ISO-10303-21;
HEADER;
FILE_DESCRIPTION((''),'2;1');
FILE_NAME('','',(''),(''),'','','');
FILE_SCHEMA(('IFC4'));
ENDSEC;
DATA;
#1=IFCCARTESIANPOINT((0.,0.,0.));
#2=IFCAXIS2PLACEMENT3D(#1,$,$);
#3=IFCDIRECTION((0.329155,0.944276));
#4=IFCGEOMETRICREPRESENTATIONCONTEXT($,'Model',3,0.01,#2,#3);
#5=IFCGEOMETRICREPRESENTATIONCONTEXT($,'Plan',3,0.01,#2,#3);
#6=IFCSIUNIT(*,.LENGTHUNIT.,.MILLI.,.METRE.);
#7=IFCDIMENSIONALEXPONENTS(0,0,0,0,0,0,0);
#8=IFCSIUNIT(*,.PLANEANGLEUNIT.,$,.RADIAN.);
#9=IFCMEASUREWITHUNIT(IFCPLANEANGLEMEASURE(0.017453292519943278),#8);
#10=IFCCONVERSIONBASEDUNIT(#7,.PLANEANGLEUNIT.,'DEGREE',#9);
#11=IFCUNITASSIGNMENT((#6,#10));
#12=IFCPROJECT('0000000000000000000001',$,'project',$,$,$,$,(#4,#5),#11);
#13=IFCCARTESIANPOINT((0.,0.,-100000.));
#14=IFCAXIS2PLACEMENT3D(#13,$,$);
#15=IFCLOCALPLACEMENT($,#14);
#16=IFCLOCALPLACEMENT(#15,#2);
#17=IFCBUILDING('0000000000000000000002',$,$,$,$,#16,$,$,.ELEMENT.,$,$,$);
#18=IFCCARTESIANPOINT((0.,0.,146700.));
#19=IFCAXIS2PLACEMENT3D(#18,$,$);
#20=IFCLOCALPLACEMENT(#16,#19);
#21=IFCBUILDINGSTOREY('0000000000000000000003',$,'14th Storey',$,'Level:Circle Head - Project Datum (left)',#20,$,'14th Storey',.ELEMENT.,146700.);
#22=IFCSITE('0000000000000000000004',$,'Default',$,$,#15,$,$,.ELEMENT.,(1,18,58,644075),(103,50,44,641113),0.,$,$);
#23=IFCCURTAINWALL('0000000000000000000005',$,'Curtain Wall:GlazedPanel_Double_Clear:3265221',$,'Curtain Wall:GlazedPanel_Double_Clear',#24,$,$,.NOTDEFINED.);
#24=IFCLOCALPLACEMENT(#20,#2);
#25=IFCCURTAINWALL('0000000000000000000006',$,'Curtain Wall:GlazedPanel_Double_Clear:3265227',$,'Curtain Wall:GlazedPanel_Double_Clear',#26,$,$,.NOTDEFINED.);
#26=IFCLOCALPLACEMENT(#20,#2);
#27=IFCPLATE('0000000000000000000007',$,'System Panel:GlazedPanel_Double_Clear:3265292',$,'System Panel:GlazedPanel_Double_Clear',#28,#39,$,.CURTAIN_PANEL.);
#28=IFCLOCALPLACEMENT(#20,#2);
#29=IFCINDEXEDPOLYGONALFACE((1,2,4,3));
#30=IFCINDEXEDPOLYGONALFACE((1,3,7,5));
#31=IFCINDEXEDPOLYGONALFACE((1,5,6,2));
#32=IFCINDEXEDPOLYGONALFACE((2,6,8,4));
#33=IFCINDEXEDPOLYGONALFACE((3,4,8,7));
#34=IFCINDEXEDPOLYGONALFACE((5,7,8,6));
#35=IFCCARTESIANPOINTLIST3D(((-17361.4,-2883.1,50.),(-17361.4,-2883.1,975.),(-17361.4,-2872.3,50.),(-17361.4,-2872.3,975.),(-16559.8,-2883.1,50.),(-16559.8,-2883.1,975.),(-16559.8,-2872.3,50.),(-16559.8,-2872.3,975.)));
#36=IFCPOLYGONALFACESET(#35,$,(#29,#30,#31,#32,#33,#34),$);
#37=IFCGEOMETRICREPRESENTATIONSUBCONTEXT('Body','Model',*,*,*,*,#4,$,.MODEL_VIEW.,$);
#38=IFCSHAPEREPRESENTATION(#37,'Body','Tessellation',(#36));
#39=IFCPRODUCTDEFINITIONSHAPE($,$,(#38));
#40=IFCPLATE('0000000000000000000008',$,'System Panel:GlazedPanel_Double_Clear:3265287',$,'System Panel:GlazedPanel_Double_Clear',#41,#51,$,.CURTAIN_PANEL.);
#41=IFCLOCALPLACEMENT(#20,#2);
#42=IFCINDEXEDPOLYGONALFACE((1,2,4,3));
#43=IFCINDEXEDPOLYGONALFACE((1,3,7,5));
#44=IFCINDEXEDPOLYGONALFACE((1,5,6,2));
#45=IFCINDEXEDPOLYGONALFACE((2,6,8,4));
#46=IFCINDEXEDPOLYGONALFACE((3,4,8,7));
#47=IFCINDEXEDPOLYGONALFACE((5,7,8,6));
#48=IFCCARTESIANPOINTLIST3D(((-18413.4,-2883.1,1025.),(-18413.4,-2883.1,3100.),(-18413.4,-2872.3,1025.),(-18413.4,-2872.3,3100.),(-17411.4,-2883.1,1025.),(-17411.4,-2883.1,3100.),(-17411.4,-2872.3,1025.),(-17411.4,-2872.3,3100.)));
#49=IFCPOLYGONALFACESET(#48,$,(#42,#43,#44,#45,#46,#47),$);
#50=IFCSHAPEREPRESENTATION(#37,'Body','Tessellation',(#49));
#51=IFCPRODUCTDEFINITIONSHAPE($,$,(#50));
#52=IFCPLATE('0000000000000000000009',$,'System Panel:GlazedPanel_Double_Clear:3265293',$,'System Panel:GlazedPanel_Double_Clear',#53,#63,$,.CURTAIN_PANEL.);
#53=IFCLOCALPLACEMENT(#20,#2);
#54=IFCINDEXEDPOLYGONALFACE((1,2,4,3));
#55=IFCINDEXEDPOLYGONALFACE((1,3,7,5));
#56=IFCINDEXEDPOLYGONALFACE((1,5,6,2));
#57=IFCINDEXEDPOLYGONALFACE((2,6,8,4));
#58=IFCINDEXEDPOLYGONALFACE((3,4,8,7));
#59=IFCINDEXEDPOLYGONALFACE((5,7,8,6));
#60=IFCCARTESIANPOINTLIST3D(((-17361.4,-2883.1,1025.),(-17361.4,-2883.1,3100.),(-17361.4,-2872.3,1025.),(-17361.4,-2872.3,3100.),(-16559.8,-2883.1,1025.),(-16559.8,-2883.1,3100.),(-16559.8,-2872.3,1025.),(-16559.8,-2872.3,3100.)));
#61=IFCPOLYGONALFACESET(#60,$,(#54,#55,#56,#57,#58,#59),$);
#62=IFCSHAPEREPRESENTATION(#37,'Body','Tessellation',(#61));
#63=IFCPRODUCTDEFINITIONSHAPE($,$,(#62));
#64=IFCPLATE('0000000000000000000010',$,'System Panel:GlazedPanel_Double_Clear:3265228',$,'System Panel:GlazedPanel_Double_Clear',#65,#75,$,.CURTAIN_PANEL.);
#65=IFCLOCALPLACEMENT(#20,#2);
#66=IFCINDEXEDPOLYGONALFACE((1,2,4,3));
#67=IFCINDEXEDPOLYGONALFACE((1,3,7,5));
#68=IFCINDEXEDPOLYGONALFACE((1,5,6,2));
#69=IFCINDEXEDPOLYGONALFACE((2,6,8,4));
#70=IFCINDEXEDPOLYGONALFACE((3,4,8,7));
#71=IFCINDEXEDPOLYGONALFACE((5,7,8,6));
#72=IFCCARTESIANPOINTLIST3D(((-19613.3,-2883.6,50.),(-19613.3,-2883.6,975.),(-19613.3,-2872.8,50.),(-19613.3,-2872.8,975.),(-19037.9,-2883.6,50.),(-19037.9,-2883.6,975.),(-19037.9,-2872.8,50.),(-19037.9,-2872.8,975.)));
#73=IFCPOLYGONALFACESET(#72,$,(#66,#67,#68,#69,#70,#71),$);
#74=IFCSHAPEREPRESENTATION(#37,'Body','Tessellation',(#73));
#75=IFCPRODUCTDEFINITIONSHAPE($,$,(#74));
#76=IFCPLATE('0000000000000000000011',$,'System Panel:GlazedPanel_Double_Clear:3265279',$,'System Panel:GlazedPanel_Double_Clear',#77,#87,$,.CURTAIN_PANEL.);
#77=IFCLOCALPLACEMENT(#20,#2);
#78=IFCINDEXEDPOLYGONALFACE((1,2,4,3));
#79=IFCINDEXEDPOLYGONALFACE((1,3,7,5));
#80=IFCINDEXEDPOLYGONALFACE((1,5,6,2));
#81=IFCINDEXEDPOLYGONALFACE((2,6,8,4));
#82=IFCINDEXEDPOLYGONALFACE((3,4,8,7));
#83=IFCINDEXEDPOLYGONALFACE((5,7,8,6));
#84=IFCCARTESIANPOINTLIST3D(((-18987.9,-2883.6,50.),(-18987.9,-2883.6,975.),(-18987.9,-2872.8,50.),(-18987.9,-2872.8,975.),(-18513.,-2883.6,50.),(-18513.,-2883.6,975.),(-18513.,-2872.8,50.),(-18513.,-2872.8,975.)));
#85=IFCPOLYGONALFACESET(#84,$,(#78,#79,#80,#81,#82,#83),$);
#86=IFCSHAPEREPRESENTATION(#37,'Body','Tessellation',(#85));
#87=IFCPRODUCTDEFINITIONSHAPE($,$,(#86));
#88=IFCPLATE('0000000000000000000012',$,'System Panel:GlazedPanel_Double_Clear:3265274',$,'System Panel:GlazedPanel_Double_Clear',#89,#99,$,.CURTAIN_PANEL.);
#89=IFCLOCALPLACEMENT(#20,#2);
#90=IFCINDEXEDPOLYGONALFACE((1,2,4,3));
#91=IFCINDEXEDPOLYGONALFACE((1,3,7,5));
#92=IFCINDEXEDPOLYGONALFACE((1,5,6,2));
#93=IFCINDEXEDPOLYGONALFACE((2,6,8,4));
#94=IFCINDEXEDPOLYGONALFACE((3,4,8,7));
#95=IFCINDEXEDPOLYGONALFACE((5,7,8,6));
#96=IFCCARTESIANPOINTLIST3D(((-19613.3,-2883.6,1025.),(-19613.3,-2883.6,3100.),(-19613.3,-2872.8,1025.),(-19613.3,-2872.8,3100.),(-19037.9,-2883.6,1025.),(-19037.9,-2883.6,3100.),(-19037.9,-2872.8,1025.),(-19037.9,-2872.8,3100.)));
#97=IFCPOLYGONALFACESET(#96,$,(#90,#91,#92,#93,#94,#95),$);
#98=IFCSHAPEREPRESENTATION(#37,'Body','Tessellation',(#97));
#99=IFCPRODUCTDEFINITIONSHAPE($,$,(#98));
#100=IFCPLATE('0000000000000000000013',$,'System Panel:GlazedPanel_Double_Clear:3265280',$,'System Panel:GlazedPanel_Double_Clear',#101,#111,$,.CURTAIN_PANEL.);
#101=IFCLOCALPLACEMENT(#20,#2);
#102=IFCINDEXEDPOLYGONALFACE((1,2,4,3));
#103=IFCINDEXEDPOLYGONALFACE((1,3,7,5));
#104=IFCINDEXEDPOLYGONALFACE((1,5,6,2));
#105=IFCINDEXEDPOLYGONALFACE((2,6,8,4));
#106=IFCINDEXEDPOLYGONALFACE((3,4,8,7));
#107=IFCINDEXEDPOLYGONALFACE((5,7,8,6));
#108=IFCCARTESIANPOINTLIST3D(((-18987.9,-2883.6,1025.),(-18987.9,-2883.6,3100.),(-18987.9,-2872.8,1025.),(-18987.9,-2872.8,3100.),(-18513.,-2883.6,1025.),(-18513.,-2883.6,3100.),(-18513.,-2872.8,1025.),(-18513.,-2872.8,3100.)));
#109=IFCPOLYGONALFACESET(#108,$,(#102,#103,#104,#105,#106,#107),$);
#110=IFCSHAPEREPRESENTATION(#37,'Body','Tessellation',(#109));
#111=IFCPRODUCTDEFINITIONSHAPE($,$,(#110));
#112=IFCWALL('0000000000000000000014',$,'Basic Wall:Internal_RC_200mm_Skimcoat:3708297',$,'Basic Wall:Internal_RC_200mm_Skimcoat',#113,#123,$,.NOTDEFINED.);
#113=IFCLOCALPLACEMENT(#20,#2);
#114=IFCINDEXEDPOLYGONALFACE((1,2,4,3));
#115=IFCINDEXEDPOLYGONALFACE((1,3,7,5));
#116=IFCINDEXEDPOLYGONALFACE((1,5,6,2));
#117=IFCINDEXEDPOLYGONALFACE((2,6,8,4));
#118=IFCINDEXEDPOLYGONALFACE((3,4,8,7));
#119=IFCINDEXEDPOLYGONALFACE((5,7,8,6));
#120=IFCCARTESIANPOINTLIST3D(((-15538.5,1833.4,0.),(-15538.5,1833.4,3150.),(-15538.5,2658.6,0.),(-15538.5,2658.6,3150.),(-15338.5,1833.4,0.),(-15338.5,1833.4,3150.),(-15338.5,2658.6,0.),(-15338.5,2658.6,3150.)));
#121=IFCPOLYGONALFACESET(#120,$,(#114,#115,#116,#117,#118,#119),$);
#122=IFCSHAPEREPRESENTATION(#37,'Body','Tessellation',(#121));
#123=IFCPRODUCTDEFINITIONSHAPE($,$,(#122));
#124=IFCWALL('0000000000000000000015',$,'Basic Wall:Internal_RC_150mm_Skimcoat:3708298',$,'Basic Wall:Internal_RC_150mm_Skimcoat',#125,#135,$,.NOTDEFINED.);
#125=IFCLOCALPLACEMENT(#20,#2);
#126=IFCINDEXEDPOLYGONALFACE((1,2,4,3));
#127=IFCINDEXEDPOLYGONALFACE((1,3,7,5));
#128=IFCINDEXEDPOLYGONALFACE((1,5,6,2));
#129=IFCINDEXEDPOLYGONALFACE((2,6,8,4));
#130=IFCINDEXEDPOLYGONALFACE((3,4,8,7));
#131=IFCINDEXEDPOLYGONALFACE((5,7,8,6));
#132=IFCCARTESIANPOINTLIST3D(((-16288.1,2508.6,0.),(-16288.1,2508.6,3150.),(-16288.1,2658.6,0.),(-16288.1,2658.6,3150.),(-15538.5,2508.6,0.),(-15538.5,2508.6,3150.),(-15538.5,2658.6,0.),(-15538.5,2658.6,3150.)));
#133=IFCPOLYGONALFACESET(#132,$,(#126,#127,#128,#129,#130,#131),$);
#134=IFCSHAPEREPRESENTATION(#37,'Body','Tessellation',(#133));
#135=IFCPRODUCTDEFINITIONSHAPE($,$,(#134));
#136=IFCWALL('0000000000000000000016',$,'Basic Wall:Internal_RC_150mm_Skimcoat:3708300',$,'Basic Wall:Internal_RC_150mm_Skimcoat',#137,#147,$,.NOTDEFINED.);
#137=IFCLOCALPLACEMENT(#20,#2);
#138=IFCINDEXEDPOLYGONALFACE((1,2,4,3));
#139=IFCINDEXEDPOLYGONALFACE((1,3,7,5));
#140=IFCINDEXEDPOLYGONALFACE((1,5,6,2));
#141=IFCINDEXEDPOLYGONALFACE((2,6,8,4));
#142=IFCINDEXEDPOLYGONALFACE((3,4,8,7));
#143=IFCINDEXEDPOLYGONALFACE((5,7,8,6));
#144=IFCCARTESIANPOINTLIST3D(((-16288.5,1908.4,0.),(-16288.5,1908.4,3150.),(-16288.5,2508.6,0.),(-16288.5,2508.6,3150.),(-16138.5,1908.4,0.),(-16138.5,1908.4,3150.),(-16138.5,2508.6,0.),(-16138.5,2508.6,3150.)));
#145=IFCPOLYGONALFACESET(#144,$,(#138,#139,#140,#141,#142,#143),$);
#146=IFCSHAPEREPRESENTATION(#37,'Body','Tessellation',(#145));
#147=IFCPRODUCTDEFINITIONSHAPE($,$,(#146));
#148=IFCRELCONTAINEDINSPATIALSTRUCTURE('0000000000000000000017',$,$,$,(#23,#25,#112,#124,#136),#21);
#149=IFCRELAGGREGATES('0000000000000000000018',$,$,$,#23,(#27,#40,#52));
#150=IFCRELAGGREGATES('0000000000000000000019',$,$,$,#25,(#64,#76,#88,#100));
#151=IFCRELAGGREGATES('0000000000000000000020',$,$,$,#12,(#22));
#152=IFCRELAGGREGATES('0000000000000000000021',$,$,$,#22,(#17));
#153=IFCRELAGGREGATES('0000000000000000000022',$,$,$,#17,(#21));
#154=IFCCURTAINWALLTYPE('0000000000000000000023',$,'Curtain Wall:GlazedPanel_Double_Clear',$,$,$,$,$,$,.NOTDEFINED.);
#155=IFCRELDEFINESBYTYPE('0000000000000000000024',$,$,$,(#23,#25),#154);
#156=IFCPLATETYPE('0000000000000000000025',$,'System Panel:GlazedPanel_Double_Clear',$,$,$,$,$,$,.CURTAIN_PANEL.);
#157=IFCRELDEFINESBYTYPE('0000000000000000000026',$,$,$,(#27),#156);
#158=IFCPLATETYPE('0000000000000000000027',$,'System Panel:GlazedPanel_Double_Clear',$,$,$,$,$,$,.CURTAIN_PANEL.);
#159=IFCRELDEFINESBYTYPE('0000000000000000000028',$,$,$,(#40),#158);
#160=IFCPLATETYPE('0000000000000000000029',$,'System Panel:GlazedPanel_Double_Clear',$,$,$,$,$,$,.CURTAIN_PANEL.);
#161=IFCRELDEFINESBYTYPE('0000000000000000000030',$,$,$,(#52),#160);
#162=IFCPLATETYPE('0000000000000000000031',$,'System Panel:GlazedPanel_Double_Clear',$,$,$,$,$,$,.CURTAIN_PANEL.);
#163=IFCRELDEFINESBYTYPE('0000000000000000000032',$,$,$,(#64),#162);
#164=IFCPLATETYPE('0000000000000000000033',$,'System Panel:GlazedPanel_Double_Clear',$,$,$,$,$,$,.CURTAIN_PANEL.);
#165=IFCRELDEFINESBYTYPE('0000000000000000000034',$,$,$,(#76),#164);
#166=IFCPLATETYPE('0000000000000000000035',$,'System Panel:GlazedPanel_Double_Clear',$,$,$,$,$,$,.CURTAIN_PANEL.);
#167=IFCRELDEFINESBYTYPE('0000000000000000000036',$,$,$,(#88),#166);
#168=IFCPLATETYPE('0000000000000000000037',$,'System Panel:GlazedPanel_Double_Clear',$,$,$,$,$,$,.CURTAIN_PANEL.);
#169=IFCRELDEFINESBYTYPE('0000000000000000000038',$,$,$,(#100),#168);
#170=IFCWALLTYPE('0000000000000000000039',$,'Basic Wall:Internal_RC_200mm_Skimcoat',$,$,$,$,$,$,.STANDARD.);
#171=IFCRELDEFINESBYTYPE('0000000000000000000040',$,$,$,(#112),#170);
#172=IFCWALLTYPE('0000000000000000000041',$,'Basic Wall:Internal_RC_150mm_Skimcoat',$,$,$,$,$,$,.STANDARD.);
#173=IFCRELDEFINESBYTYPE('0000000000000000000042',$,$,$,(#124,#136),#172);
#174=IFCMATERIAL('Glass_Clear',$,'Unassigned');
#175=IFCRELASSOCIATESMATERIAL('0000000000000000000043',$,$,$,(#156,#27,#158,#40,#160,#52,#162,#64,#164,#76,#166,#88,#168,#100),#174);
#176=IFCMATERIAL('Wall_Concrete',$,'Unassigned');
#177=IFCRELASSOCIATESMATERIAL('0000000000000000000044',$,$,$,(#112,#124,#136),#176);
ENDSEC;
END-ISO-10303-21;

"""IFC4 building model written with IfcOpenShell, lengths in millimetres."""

from ifc_helpers import new_model, entity, si_unit, converted_unit, direction, frame, origin, place, context, subcontext, project, spatial, indexed_curve, outline, extrude, source, transform, mapped, material, type_object, type_shapes, element, aggregate, save


model = new_model("IFC4")

# Units and contexts
model_context = context("Model", 3, precision=0.01, world=origin(), true_north=direction((0.329155, 0.944276)))
plan_context = context("Plan", 3, precision=0.01, world=origin(), true_north=direction((0.329155, 0.944276)))
body_context = subcontext(model_context, "Body", "Model", "MODEL_VIEW")
ifc_project = project(units=[si_unit("LENGTHUNIT", "METRE", prefix="MILLI"), converted_unit("PLANEANGLEUNIT", "DEGREE", entity("IfcPlaneAngleMeasure", 0.017453292519943278), si_unit("PLANEANGLEUNIT", "RADIAN"), dimensions=[0, 0, 0, 0, 0, 0, 0])], contexts=[model_context, plan_context])

# Site, building, storey
site_placement = place(None, frame((0.0, 0.0, -100000.0)))
site = spatial("IfcSite", under=ifc_project, at=site_placement, Name="Default", CompositionType="ELEMENT", RefLatitude=(1, 18, 58, 644075), RefLongitude=(103, 50, 44, 641113), RefElevation=0.0)
building_placement = place(site_placement, origin())
building = spatial("IfcBuilding", under=site, at=building_placement, CompositionType="ELEMENT")
storey_placement = place(building_placement, frame((0.0, 0.0, 146700.0)))
storey = spatial("IfcBuildingStorey", under=building, at=storey_placement, Name="14th Storey", ObjectType="Level:Circle Head - Project Datum (left)", LongName="14th Storey", CompositionType="ELEMENT", Elevation=146700.0)

# Curtain wall
curtain_wall_type = type_object("IfcCurtainWallType", Name="Curtain Wall:GlazedPanel_Double_Clear", PredefinedType="NOTDEFINED")
curtain_wall_1_placement = place(storey_placement, frame((0.0, 0.0, -146700.0)))
curtain_wall_1 = element("IfcCurtainWall", 1, at=curtain_wall_1_placement, inside=storey, type_object=curtain_wall_type, Name="Curtain Wall:GlazedPanel_Double_Clear:3265221", ObjectType="Curtain Wall:GlazedPanel_Double_Clear", PredefinedType="NOTDEFINED")

# Curtain wall
curtain_wall_2_placement = place(storey_placement, frame((0.0, 0.0, -146700.0)))
curtain_wall_2 = element("IfcCurtainWall", 2, at=curtain_wall_2_placement, inside=storey, type_object=curtain_wall_type, Name="Curtain Wall:GlazedPanel_Double_Clear:3265227", ObjectType="Curtain Wall:GlazedPanel_Double_Clear", PredefinedType="NOTDEFINED")

# Plates
ifc_material_1 = material(Name="Glass_Clear", Category="Unassigned")
plate_type_1 = type_object("IfcPlateType", Name="System Panel:GlazedPanel_Double_Clear", PredefinedType="CURTAIN_PANEL", material=ifc_material_1)
shared_shape_1 = source(origin(), body_context, "Body", "SweptSolid", [
    extrude(outline(indexed_curve([(-5.4, -400.8), (5.4, -400.8), (5.4, 400.8), (-5.4, 400.8), (-5.4, -400.8)], self_intersect=False)), frame((400.8, 5.4, 0.0), z_axis=(0.0, 0.0, 1.0), x_axis=(0.0, 1.0, 0.0)), (0.0, 0.0, 1.0), 925.0),
])
type_shapes(plate_type_1, [shared_shape_1])
plate_1_placement = place(curtain_wall_1_placement, frame((-17361.4, -2883.1, 146750.0)))
plate_1 = element("IfcPlate", 3, at=plate_1_placement, type_object=plate_type_1, material=ifc_material_1, Name="System Panel:GlazedPanel_Double_Clear:3265292", ObjectType="System Panel:GlazedPanel_Double_Clear", PredefinedType="CURTAIN_PANEL", context=body_context, shape_type="MappedRepresentation", body=[
    mapped(shared_shape_1, transform((0.0, 0.0, 0.0), scale=1.0)),
])
plate_type_2 = type_object("IfcPlateType", Name="System Panel:GlazedPanel_Double_Clear", PredefinedType="CURTAIN_PANEL", material=ifc_material_1)
shared_shape_2 = source(origin(), body_context, "Body", "SweptSolid", [
    extrude(outline(indexed_curve([(-5.4, -501.0), (5.4, -501.0), (5.4, 501.0), (-5.4, 501.0), (-5.4, -501.0)], self_intersect=False)), frame((501.0, 5.4, 0.0), z_axis=(0.0, 0.0, 1.0), x_axis=(0.0, 1.0, 0.0)), (0.0, 0.0, 1.0), 2075.0),
])
type_shapes(plate_type_2, [shared_shape_2])
plate_2_placement = place(curtain_wall_1_placement, frame((-18413.4, -2883.1, 147725.0)))
plate_2 = element("IfcPlate", 4, at=plate_2_placement, type_object=plate_type_2, material=ifc_material_1, Name="System Panel:GlazedPanel_Double_Clear:3265287", ObjectType="System Panel:GlazedPanel_Double_Clear", PredefinedType="CURTAIN_PANEL", context=body_context, shape_type="MappedRepresentation", body=[
    mapped(shared_shape_2, transform((0.0, 0.0, 0.0), scale=1.0)),
])
plate_type_3 = type_object("IfcPlateType", Name="System Panel:GlazedPanel_Double_Clear", PredefinedType="CURTAIN_PANEL", material=ifc_material_1)
shared_shape_3 = source(origin(), body_context, "Body", "SweptSolid", [
    extrude(outline(indexed_curve([(-5.4, -400.8), (5.4, -400.8), (5.4, 400.8), (-5.4, 400.8), (-5.4, -400.8)], self_intersect=False)), frame((400.8, 5.4, 0.0), z_axis=(0.0, 0.0, 1.0), x_axis=(0.0, 1.0, 0.0)), (0.0, 0.0, 1.0), 2075.0),
])
type_shapes(plate_type_3, [shared_shape_3])
plate_3_placement = place(curtain_wall_1_placement, frame((-17361.4, -2883.1, 147725.0)))
plate_3 = element("IfcPlate", 5, at=plate_3_placement, type_object=plate_type_3, material=ifc_material_1, Name="System Panel:GlazedPanel_Double_Clear:3265293", ObjectType="System Panel:GlazedPanel_Double_Clear", PredefinedType="CURTAIN_PANEL", context=body_context, shape_type="MappedRepresentation", body=[
    mapped(shared_shape_3, transform((0.0, 0.0, 0.0), scale=1.0)),
])
aggregate(curtain_wall_1, [plate_1, plate_2, plate_3])
plate_type_4 = type_object("IfcPlateType", Name="System Panel:GlazedPanel_Double_Clear", PredefinedType="CURTAIN_PANEL", material=ifc_material_1)
shared_shape_4 = source(origin(), body_context, "Body", "SweptSolid", [
    extrude(outline(indexed_curve([(-5.4, -287.7), (5.4, -287.7), (5.4, 287.7), (-5.4, 287.7), (-5.4, -287.7)], self_intersect=False)), frame((287.7, 5.4, 0.0), z_axis=(0.0, 0.0, 1.0), x_axis=(0.0, 1.0, 0.0)), (0.0, 0.0, 1.0), 925.0),
])
type_shapes(plate_type_4, [shared_shape_4])
plate_4_placement = place(curtain_wall_2_placement, frame((-19613.3, -2883.6, 146750.0)))
plate_4 = element("IfcPlate", 6, at=plate_4_placement, type_object=plate_type_4, material=ifc_material_1, Name="System Panel:GlazedPanel_Double_Clear:3265228", ObjectType="System Panel:GlazedPanel_Double_Clear", PredefinedType="CURTAIN_PANEL", context=body_context, shape_type="MappedRepresentation", body=[
    mapped(shared_shape_4, transform((0.0, 0.0, 0.0), scale=1.0)),
])
plate_type_5 = type_object("IfcPlateType", Name="System Panel:GlazedPanel_Double_Clear", PredefinedType="CURTAIN_PANEL", material=ifc_material_1)
shared_shape_5 = source(origin(), body_context, "Body", "SweptSolid", [
    extrude(outline(indexed_curve([(-5.4, -237.5), (5.4, -237.5), (5.4, 237.5), (-5.4, 237.5), (-5.4, -237.5)], self_intersect=False)), frame((237.5, 5.4, 0.0), z_axis=(0.0, 0.0, 1.0), x_axis=(0.0, 1.0, 0.0)), (0.0, 0.0, 1.0), 925.0),
])
type_shapes(plate_type_5, [shared_shape_5])
plate_5_placement = place(curtain_wall_2_placement, frame((-18987.9, -2883.6, 146750.0)))
plate_5 = element("IfcPlate", 7, at=plate_5_placement, type_object=plate_type_5, material=ifc_material_1, Name="System Panel:GlazedPanel_Double_Clear:3265279", ObjectType="System Panel:GlazedPanel_Double_Clear", PredefinedType="CURTAIN_PANEL", context=body_context, shape_type="MappedRepresentation", body=[
    mapped(shared_shape_5, transform((0.0, 0.0, 0.0), scale=1.0)),
])
plate_type_6 = type_object("IfcPlateType", Name="System Panel:GlazedPanel_Double_Clear", PredefinedType="CURTAIN_PANEL", material=ifc_material_1)
shared_shape_6 = source(origin(), body_context, "Body", "SweptSolid", [
    extrude(outline(indexed_curve([(-5.4, -287.7), (5.4, -287.7), (5.4, 287.7), (-5.4, 287.7), (-5.4, -287.7)], self_intersect=False)), frame((287.7, 5.4, 0.0), z_axis=(0.0, 0.0, 1.0), x_axis=(0.0, 1.0, 0.0)), (0.0, 0.0, 1.0), 2075.0),
])
type_shapes(plate_type_6, [shared_shape_6])
plate_6_placement = place(curtain_wall_2_placement, frame((-19613.3, -2883.6, 147725.0)))
plate_6 = element("IfcPlate", 8, at=plate_6_placement, type_object=plate_type_6, material=ifc_material_1, Name="System Panel:GlazedPanel_Double_Clear:3265274", ObjectType="System Panel:GlazedPanel_Double_Clear", PredefinedType="CURTAIN_PANEL", context=body_context, shape_type="MappedRepresentation", body=[
    mapped(shared_shape_6, transform((0.0, 0.0, 0.0), scale=1.0)),
])
plate_type_7 = type_object("IfcPlateType", Name="System Panel:GlazedPanel_Double_Clear", PredefinedType="CURTAIN_PANEL", material=ifc_material_1)
shared_shape_7 = source(origin(), body_context, "Body", "SweptSolid", [
    extrude(outline(indexed_curve([(-5.4, -237.5), (5.4, -237.5), (5.4, 237.5), (-5.4, 237.5), (-5.4, -237.5)], self_intersect=False)), frame((237.5, 5.4, 0.0), z_axis=(0.0, 0.0, 1.0), x_axis=(0.0, 1.0, 0.0)), (0.0, 0.0, 1.0), 2075.0),
])
type_shapes(plate_type_7, [shared_shape_7])
plate_7_placement = place(curtain_wall_2_placement, frame((-18987.9, -2883.6, 147725.0)))
plate_7 = element("IfcPlate", 9, at=plate_7_placement, type_object=plate_type_7, material=ifc_material_1, Name="System Panel:GlazedPanel_Double_Clear:3265280", ObjectType="System Panel:GlazedPanel_Double_Clear", PredefinedType="CURTAIN_PANEL", context=body_context, shape_type="MappedRepresentation", body=[
    mapped(shared_shape_7, transform((0.0, 0.0, 0.0), scale=1.0)),
])
aggregate(curtain_wall_2, [plate_4, plate_5, plate_6, plate_7])

# Walls
ifc_material_2 = material(Name="Wall_Concrete", Category="Unassigned")
wall_type_1 = type_object("IfcWallType", Name="Basic Wall:Internal_RC_200mm_Skimcoat", PredefinedType="STANDARD")
wall_1_placement = place(storey_placement, frame((-15438.5, 2658.6, 0.0), z_axis=(0.0, 0.0, 1.0), x_axis=(0.0, -1.0, 0.0)))
element("IfcWall", 10, at=wall_1_placement, inside=storey, type_object=wall_type_1, material=ifc_material_2, Name="Basic Wall:Internal_RC_200mm_Skimcoat:3708297", ObjectType="Basic Wall:Internal_RC_200mm_Skimcoat", PredefinedType="NOTDEFINED", context=body_context, shape_type="SweptSolid", body=[
    extrude(outline(indexed_curve([(825.1, 100.0), (0.0, 100.0), (0.0, -100.0), (825.1, -100.0), (825.1, 100.0)], self_intersect=False)), origin(), (0.0, 0.0, 1.0), 3150.0),
])
wall_type_2 = type_object("IfcWallType", Name="Basic Wall:Internal_RC_150mm_Skimcoat", PredefinedType="STANDARD")
wall_2_placement = place(storey_placement, frame((-16288.1, 2583.6, 0.0)))
element("IfcWall", 11, at=wall_2_placement, inside=storey, type_object=wall_type_2, material=ifc_material_2, Name="Basic Wall:Internal_RC_150mm_Skimcoat:3708298", ObjectType="Basic Wall:Internal_RC_150mm_Skimcoat", PredefinedType="NOTDEFINED", context=body_context, shape_type="SweptSolid", body=[
    extrude(outline(indexed_curve([(749.6, 75.0), (0.0, 75.0), (0.0, -75.0), (749.6, -75.0), (749.6, 75.0)], self_intersect=False)), origin(), (0.0, 0.0, 1.0), 3150.0),
])
wall_3_placement = place(storey_placement, frame((-16213.5, 2508.6, 0.0), z_axis=(0.0, 0.0, 1.0), x_axis=(0.0, -1.0, 0.0)))
element("IfcWall", 12, at=wall_3_placement, inside=storey, type_object=wall_type_2, material=ifc_material_2, Name="Basic Wall:Internal_RC_150mm_Skimcoat:3708300", ObjectType="Basic Wall:Internal_RC_150mm_Skimcoat", PredefinedType="NOTDEFINED", context=body_context, shape_type="SweptSolid", body=[
    extrude(outline(indexed_curve([(600.1, 75.0), (0.0, 75.0), (0.0, -75.0), (600.1, -75.0), (600.1, 75.0)], self_intersect=False)), origin(), (0.0, 0.0, 1.0), 3150.0),
])

save(model, "model.ifc")
